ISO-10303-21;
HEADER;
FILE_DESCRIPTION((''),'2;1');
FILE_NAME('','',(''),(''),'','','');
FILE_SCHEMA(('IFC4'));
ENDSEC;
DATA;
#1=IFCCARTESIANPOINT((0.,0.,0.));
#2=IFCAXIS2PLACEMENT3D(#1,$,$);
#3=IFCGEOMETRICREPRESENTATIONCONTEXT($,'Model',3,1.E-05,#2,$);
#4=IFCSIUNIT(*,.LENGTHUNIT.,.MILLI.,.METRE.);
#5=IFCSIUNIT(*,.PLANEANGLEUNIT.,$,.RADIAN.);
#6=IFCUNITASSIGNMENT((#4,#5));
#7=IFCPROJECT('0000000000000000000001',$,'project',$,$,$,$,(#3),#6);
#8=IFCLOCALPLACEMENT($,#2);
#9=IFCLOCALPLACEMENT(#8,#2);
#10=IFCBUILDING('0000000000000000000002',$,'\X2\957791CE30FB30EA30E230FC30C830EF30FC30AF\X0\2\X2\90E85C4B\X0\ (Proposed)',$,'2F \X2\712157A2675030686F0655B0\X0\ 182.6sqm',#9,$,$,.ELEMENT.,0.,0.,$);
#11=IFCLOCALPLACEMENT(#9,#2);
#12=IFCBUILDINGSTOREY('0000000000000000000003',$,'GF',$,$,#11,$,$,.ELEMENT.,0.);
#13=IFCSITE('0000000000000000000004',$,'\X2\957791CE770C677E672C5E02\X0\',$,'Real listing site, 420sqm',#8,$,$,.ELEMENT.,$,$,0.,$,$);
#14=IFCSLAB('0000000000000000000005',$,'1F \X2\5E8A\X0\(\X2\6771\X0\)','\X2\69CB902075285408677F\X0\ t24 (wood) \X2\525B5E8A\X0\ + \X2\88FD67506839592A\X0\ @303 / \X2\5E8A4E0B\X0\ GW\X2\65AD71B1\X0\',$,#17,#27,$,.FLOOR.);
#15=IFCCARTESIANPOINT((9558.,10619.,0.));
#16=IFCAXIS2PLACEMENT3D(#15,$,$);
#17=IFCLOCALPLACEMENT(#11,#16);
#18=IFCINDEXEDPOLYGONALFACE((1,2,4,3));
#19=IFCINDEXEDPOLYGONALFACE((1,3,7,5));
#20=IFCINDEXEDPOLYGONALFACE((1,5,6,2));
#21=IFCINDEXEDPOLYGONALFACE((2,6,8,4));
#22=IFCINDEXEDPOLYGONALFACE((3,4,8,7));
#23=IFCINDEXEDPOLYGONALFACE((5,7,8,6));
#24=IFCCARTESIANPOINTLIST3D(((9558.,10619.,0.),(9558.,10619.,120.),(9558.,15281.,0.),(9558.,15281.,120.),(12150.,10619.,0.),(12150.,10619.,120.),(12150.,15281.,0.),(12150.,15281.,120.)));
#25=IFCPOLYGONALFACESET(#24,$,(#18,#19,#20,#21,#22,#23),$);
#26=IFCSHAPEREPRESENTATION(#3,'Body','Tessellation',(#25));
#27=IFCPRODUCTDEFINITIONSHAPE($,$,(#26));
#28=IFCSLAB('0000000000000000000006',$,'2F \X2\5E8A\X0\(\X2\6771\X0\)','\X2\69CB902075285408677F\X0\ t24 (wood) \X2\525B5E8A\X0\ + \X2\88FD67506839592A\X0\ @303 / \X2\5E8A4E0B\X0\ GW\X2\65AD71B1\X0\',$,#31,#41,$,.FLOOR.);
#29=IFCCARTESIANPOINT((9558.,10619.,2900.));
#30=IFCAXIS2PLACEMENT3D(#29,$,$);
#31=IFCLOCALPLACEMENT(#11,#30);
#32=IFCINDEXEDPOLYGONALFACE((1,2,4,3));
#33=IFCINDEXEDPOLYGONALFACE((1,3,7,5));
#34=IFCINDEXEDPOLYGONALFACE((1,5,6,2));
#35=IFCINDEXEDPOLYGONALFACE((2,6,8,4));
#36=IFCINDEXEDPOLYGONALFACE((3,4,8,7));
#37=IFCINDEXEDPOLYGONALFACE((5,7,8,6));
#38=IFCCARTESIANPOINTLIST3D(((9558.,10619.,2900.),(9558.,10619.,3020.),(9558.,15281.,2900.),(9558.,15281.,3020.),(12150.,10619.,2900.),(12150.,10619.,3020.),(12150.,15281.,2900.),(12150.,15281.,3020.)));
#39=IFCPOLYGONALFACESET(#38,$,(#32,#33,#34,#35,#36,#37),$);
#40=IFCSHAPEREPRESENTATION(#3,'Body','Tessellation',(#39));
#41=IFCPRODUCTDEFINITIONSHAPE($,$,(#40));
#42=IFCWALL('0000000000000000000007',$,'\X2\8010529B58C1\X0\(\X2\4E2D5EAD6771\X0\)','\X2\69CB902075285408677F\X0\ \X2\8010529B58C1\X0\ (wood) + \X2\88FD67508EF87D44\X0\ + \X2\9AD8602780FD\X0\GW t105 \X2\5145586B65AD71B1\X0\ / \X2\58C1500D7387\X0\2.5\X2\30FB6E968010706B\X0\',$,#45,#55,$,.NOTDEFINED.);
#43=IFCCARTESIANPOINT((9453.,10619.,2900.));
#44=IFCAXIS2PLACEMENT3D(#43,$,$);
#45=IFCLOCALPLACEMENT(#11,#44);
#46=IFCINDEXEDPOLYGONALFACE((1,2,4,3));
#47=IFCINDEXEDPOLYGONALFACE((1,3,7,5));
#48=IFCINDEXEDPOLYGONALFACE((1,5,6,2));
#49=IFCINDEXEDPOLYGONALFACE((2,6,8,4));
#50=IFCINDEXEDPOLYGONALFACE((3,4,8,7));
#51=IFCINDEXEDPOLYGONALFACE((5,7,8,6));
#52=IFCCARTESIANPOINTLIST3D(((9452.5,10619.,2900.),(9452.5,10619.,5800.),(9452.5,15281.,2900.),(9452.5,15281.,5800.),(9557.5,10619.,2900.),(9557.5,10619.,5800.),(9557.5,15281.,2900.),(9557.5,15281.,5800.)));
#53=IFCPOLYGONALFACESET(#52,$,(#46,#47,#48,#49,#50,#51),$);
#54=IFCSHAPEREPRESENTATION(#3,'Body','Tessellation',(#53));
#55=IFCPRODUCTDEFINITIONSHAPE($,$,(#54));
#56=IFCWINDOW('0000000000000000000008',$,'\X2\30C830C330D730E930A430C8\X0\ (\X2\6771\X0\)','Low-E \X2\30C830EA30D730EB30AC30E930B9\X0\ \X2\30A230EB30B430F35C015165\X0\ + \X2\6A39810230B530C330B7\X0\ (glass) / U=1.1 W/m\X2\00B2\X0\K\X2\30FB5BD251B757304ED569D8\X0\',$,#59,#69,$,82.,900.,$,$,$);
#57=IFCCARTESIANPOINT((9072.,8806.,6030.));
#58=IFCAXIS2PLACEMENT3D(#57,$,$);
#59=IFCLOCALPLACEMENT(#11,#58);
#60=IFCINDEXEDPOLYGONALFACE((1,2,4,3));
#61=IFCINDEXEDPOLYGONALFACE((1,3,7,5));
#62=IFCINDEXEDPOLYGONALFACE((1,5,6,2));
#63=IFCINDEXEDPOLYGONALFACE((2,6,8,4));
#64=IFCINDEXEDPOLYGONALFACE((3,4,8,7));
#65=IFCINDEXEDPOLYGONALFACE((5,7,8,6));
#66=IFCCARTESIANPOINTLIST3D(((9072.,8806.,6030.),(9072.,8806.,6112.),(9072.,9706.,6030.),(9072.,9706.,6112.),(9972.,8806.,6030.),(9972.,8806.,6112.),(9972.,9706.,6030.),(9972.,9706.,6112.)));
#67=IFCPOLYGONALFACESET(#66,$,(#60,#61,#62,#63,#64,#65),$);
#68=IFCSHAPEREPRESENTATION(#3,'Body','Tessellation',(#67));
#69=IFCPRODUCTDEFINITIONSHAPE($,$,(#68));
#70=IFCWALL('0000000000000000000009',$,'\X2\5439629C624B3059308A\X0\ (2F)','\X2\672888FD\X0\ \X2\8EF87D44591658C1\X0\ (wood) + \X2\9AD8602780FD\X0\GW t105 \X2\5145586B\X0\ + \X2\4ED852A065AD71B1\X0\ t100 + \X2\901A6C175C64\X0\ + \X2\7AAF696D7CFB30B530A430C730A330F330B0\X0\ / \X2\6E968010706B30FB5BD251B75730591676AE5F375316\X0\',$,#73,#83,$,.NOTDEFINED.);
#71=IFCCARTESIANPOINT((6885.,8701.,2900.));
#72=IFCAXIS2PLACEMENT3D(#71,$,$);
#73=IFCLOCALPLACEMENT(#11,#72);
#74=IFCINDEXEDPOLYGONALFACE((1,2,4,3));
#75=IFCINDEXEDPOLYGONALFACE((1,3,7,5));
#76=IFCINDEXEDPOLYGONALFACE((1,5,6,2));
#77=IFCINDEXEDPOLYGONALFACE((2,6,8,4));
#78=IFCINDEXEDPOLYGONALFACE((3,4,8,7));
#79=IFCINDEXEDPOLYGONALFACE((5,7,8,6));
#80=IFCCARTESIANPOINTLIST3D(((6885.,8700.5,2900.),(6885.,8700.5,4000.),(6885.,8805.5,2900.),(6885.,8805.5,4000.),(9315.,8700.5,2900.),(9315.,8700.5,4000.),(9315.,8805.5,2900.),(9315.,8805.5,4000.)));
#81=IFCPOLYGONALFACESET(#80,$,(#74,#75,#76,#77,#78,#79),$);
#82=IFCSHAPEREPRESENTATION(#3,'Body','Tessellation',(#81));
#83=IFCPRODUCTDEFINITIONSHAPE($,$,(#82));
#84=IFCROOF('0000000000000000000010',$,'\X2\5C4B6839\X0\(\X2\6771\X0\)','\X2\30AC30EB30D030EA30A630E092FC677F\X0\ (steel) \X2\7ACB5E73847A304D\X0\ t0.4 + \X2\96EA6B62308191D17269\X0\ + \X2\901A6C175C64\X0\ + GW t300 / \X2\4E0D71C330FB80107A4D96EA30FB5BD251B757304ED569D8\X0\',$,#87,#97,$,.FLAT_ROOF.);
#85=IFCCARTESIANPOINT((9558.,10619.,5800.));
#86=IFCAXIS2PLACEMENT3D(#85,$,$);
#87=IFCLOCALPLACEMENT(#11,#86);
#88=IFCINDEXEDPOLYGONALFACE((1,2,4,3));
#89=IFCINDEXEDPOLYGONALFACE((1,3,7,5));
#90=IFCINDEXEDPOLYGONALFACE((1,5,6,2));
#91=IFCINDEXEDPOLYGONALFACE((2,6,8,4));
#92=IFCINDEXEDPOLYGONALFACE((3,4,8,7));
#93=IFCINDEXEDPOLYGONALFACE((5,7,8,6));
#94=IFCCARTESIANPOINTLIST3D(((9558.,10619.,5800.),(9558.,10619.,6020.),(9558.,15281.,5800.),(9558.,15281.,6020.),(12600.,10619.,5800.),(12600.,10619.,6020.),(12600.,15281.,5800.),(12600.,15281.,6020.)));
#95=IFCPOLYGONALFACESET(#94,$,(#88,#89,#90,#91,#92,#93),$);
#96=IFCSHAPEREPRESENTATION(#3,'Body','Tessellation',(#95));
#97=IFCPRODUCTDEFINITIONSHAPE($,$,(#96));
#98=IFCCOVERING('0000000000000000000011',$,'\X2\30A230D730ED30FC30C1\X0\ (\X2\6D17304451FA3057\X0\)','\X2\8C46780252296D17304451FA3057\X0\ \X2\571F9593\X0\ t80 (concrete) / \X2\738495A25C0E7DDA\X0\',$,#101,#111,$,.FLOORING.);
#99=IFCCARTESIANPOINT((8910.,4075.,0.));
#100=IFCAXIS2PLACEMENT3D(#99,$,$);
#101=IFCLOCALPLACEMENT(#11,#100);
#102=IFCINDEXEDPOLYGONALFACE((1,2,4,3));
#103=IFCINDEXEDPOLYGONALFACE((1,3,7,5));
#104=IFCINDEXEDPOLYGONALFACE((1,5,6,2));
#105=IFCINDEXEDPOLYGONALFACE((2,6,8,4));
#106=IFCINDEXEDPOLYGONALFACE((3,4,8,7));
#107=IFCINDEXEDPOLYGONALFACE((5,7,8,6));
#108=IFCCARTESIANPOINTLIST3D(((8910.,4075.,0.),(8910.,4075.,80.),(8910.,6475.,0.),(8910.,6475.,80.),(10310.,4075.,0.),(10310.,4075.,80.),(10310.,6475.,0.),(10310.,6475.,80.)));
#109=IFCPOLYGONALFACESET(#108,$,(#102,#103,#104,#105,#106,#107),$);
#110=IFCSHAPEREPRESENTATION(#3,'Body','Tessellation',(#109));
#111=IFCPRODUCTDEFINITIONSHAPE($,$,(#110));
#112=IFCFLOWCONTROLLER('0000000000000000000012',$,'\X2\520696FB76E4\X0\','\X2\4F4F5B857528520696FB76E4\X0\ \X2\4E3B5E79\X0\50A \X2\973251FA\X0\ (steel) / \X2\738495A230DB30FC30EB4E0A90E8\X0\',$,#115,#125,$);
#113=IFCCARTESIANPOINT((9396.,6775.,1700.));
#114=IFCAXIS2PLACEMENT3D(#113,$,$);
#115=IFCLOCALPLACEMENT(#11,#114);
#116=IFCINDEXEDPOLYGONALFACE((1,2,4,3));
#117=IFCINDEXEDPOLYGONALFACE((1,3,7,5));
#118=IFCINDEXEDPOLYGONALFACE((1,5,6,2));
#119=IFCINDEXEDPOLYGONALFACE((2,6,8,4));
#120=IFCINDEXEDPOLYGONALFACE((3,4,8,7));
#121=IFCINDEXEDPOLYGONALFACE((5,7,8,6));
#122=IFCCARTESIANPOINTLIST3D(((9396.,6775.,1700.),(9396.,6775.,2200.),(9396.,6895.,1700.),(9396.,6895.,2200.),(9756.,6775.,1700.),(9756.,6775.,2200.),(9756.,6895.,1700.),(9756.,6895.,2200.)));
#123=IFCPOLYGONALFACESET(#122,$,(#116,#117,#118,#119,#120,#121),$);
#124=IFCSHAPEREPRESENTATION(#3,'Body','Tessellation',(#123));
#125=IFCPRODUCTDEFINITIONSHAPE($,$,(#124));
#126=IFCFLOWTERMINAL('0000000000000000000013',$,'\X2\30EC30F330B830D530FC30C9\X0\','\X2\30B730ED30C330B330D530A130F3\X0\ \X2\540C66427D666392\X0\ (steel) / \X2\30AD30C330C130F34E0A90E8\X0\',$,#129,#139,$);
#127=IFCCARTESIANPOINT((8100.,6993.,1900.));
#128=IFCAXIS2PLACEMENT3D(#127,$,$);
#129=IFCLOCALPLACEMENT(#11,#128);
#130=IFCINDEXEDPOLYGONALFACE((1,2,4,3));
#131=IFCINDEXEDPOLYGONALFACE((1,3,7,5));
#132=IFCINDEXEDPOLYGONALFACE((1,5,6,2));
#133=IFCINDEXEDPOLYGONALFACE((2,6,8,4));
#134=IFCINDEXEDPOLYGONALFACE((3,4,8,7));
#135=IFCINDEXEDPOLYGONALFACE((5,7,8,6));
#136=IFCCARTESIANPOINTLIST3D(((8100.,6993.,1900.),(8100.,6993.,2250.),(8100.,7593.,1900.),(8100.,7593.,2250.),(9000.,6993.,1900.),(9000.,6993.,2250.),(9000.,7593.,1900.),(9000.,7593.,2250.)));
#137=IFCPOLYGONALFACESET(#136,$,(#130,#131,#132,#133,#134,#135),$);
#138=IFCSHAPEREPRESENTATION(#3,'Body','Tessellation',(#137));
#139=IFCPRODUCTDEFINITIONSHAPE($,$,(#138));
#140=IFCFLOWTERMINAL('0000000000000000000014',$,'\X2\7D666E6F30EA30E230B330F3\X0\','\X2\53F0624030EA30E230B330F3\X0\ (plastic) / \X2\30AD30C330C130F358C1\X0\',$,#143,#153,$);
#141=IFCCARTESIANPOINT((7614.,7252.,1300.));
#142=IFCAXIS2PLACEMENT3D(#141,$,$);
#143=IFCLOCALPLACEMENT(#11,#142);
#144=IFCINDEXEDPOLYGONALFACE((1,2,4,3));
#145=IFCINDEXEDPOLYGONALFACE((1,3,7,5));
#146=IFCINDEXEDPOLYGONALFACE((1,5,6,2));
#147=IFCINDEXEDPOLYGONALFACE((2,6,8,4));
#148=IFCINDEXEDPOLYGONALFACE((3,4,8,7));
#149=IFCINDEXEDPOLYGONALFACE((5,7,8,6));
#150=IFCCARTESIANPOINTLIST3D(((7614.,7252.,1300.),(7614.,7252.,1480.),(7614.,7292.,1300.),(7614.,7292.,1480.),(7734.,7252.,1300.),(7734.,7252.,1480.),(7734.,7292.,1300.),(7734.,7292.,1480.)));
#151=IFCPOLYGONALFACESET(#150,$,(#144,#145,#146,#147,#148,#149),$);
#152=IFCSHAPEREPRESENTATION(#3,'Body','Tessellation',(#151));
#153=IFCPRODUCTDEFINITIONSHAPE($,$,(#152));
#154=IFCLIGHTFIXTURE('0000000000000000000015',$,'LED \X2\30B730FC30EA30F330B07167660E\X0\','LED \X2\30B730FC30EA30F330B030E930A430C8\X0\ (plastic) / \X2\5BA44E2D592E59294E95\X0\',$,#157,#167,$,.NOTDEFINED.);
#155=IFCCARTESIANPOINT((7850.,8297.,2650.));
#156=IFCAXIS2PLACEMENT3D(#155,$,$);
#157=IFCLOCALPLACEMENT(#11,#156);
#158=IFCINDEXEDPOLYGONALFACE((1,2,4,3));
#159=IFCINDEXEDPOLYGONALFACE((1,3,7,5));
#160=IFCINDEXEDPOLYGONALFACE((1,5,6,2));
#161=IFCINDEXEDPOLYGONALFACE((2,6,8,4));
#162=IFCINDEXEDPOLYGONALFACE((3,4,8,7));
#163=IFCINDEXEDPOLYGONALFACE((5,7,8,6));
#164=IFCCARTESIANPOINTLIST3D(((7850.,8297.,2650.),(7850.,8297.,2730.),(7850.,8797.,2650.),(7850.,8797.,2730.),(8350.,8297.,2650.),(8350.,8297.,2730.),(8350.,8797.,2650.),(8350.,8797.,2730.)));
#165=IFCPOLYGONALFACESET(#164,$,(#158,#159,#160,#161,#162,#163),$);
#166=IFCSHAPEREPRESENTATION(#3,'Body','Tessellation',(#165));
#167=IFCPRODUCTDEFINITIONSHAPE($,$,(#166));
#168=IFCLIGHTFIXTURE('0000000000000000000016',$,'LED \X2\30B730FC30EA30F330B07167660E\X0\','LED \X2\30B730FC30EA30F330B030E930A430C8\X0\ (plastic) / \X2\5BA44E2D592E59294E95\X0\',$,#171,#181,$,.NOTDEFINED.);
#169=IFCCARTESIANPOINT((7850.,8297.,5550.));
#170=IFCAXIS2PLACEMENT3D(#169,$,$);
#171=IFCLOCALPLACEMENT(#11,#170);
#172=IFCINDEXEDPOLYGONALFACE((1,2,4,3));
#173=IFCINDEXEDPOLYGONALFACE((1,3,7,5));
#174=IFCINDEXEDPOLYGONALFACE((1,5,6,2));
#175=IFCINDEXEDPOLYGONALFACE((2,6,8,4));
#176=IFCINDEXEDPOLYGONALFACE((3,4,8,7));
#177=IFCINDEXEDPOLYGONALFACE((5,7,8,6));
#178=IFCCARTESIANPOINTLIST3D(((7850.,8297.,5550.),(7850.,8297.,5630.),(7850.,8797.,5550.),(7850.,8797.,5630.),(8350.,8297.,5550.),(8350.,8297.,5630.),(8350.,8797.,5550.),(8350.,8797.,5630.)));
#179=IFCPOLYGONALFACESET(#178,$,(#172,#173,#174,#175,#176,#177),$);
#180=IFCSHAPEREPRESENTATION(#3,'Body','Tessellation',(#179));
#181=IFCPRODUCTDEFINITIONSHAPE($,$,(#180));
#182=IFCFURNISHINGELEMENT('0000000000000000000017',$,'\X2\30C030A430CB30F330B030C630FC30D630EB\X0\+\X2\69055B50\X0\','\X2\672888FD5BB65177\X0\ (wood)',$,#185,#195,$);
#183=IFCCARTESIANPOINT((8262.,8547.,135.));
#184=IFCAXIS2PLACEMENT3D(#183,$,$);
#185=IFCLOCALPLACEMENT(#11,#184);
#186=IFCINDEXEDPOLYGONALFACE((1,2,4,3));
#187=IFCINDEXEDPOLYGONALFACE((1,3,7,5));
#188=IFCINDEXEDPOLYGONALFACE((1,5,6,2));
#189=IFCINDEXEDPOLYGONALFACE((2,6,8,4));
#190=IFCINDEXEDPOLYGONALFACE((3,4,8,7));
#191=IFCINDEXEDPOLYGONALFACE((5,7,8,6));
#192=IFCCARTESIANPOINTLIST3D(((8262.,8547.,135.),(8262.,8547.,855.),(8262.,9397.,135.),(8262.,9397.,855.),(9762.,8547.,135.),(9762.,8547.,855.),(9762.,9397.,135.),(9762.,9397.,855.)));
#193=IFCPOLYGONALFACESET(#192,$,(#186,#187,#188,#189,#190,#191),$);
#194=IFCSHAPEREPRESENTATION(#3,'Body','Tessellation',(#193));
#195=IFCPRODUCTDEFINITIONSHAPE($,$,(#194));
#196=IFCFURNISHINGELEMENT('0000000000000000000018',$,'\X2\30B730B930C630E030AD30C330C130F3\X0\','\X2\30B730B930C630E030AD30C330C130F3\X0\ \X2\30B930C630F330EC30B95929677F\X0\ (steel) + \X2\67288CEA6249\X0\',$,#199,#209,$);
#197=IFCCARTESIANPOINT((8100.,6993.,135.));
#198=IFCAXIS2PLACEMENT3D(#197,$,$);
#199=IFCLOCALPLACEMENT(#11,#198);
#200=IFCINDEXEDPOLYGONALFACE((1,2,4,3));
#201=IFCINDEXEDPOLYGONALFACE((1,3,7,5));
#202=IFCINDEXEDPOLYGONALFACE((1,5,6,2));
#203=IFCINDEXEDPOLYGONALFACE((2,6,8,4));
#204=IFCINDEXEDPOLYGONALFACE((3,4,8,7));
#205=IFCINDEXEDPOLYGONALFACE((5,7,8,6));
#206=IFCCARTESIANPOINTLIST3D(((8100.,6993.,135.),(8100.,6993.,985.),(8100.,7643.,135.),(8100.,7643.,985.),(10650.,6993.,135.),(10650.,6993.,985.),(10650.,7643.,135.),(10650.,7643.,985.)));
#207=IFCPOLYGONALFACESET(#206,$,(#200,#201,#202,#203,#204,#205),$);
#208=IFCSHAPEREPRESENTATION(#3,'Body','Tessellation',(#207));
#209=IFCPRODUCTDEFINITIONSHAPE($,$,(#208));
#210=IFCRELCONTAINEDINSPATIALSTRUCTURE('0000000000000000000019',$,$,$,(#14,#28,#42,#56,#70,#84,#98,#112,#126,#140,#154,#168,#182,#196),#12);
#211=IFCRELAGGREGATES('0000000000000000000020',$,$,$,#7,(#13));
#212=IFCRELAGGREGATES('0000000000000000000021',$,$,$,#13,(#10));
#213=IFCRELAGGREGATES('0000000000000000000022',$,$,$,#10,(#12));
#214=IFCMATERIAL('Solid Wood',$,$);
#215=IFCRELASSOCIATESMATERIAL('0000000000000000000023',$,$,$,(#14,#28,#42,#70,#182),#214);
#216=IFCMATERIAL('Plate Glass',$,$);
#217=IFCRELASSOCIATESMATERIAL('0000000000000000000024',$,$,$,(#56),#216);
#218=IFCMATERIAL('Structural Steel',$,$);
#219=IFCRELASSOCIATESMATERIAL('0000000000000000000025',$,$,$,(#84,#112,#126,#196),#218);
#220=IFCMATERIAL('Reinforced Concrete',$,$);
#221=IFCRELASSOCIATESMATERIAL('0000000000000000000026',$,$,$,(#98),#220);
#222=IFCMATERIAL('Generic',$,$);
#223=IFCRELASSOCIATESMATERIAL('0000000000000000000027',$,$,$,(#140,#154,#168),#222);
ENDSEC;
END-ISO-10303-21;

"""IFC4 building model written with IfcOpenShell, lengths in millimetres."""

from ifc_helpers import new_model, si_unit, frame, frame_2d, origin, place, context, project, spatial, rectangle, extrude, material, element, save


model = new_model("IFC4")

# Units and contexts
model_context = context("Model", 3, precision=1e-05, world=origin())
ifc_project = project(units=[si_unit("LENGTHUNIT", "METRE", prefix="MILLI"), si_unit("PLANEANGLEUNIT", "RADIAN")], contexts=[model_context])

# Site, building, storey
site_placement = place(None, origin())
site = spatial("IfcSite", under=ifc_project, at=site_placement, Name="長野県松本市", ObjectType="Real listing site, 420sqm", CompositionType="ELEMENT", RefElevation=0.0)
building_placement = place(site_placement, origin())
building = spatial("IfcBuilding", under=site, at=building_placement, Name="長野・リモートワーク2部屋 (Proposed)", ObjectType="2F 無垢材と漆喰 182.6sqm", CompositionType="ELEMENT", ElevationOfRefHeight=0.0, ElevationOfTerrain=0.0)
storey_placement = place(building_placement, origin())
storey = spatial("IfcBuildingStorey", under=building, at=storey_placement, Name="GF", CompositionType="ELEMENT", Elevation=0.0)

# Shared definitions
ifc_material_1 = material(Name="Solid Wood")

# Slabs
slab_1_placement = place(storey_placement, frame((9558.0, 10619.0, 0.0)))
element("IfcSlab", 1, at=slab_1_placement, inside=storey, material=ifc_material_1, Name="1F 床(東)", Description="構造用合板 t24 (wood) 剛床 + 製材根太 @303 / 床下 GW断熱", PredefinedType="FLOOR", context=model_context, shape_type="SweptSolid", body=[
    extrude(rectangle(XDim=2592.0, YDim=4662.0, at=frame_2d((1296.0, 2331.0))), frame((9558.0, 10619.0, 0.0)), (0.0, 0.0, 1.0), 120.0),
])
slab_2_placement = place(storey_placement, frame((9558.0, 10619.0, 2900.0)))
element("IfcSlab", 2, at=slab_2_placement, inside=storey, material=ifc_material_1, Name="2F 床(東)", Description="構造用合板 t24 (wood) 剛床 + 製材根太 @303 / 床下 GW断熱", PredefinedType="FLOOR", context=model_context, shape_type="SweptSolid", body=[
    extrude(rectangle(XDim=2592.0, YDim=4662.0, at=frame_2d((1296.0, 2331.0))), frame((9558.0, 10619.0, 2900.0)), (0.0, 0.0, 1.0), 120.0),
])

# Wall
wall_1_placement = place(storey_placement, frame((9453.0, 10619.0, 2900.0)))
element("IfcWall", 3, at=wall_1_placement, inside=storey, material=ifc_material_1, Name="耐力壁(中庭東)", Description="構造用合板 耐力壁 (wood) + 製材軸組 + 高性能GW t105 充填断熱 / 壁倍率2.5・準耐火", PredefinedType="NOTDEFINED", context=model_context, shape_type="SweptSolid", body=[
    extrude(rectangle(XDim=105.0, YDim=4662.0, at=frame_2d((52.0, 2331.0))), frame((9453.0, 10619.0, 2900.0)), (0.0, 0.0, 1.0), 2900.0),
])

# Window
ifc_material_2 = material(Name="Plate Glass")
window_placement = place(storey_placement, frame((9072.0, 8806.0, 6030.0)))
element("IfcWindow", 4, at=window_placement, inside=storey, material=ifc_material_2, Name="トップライト (東)", Description="Low-E トリプルガラス アルゴン封入 + 樹脂サッシ (glass) / U=1.1 W/m²K・寒冷地仕様", OverallHeight=82.0, OverallWidth=900.0, context=model_context, shape_type="SweptSolid", body=[
    extrude(rectangle(XDim=900.0, YDim=900.0, at=frame_2d((450.0, 450.0))), frame((9072.0, 8806.0, 6030.0)), (0.0, 0.0, 1.0), 82.0),
])

# Wall
wall_2_placement = place(storey_placement, frame((6885.0, 8701.0, 2900.0)))
element("IfcWall", 5, at=wall_2_placement, inside=storey, material=ifc_material_1, Name="吹抜手すり (2F)", Description="木製 軸組外壁 (wood) + 高性能GW t105 充填 + 付加断熱 t100 + 通気層 + 窯業系サイディング / 準耐火・寒冷地外皮強化", PredefinedType="NOTDEFINED", context=model_context, shape_type="SweptSolid", body=[
    extrude(rectangle(XDim=2430.0, YDim=105.0, at=frame_2d((1215.0, 52.0))), frame((6885.0, 8701.0, 2900.0)), (0.0, 0.0, 1.0), 1100.0),
])

# Roof
ifc_material_3 = material(Name="Structural Steel")
roof_placement = place(storey_placement, frame((9558.0, 10619.0, 5800.0)))
element("IfcRoof", 6, at=roof_placement, inside=storey, material=ifc_material_3, Name="屋根(東)", Description="ガルバリウム鋼板 (steel) 立平葺き t0.4 + 雪止め金物 + 通気層 + GW t300 / 不燃・耐積雪・寒冷地仕様", PredefinedType="FLAT_ROOF", context=model_context, shape_type="SweptSolid", body=[
    extrude(rectangle(XDim=3042.0, YDim=4662.0, at=frame_2d((1521.0, 2331.0))), frame((9558.0, 10619.0, 5800.0)), (0.0, 0.0, 1.0), 220.0),
])

# Covering
ifc_material_4 = material(Name="Reinforced Concrete")
covering_placement = place(storey_placement, frame((8910.0, 4075.0, 0.0)))
element("IfcCovering", 7, at=covering_placement, inside=storey, material=ifc_material_4, Name="アプローチ (洗い出し)", Description="豆砂利洗い出し 土間 t80 (concrete) / 玄関導線", PredefinedType="FLOORING", context=model_context, shape_type="SweptSolid", body=[
    extrude(rectangle(XDim=1400.0, YDim=2400.0, at=frame_2d((700.0, 1200.0))), frame((8910.0, 4075.0, 0.0)), (0.0, 0.0, 1.0), 80.0),
])

# Flow controller
flow_controller_placement = place(storey_placement, frame((9396.0, 6775.0, 1700.0)))
element("IfcFlowController", 8, at=flow_controller_placement, inside=storey, material=ifc_material_3, Name="分電盤", Description="住宅用分電盤 主幹50A 露出 (steel) / 玄関ホール上部", context=model_context, shape_type="SweptSolid", body=[
    extrude(rectangle(XDim=360.0, YDim=120.0, at=frame_2d((180.0, 60.0))), frame((9396.0, 6775.0, 1700.0)), (0.0, 0.0, 1.0), 500.0),
])

# Flow terminals
flow_terminal_1_placement = place(storey_placement, frame((8100.0, 6993.0, 1900.0)))
element("IfcFlowTerminal", 9, at=flow_terminal_1_placement, inside=storey, material=ifc_material_3, Name="レンジフード", Description="シロッコファン 同時給排 (steel) / キッチン上部", context=model_context, shape_type="SweptSolid", body=[
    extrude(rectangle(XDim=900.0, YDim=600.0, at=frame_2d((450.0, 300.0))), frame((8100.0, 6993.0, 1900.0)), (0.0, 0.0, 1.0), 350.0),
])
ifc_material_5 = material(Name="Generic")
flow_terminal_2_placement = place(storey_placement, frame((7614.0, 7252.0, 1300.0)))
element("IfcFlowTerminal", 10, at=flow_terminal_2_placement, inside=storey, material=ifc_material_5, Name="給湯リモコン", Description="台所リモコン (plastic) / キッチン壁", context=model_context, shape_type="SweptSolid", body=[
    extrude(rectangle(XDim=120.0, YDim=40.0, at=frame_2d((60.0, 20.0))), frame((7614.0, 7252.0, 1300.0)), (0.0, 0.0, 1.0), 180.0),
])

# Light fixtures
light_fixture_1_placement = place(storey_placement, frame((7850.0, 8297.0, 2650.0)))
element("IfcLightFixture", 11, at=light_fixture_1_placement, inside=storey, material=ifc_material_5, Name="LED シーリング照明", Description="LED シーリングライト (plastic) / 室中央天井", PredefinedType="NOTDEFINED", context=model_context, shape_type="SweptSolid", body=[
    extrude(rectangle(XDim=500.0, YDim=500.0, at=frame_2d((250.0, 250.0))), frame((7850.0, 8297.0, 2650.0)), (0.0, 0.0, 1.0), 80.0),
])
light_fixture_2_placement = place(storey_placement, frame((7850.0, 8297.0, 5550.0)))
element("IfcLightFixture", 12, at=light_fixture_2_placement, inside=storey, material=ifc_material_5, Name="LED シーリング照明", Description="LED シーリングライト (plastic) / 室中央天井", PredefinedType="NOTDEFINED", context=model_context, shape_type="SweptSolid", body=[
    extrude(rectangle(XDim=500.0, YDim=500.0, at=frame_2d((250.0, 250.0))), frame((7850.0, 8297.0, 5550.0)), (0.0, 0.0, 1.0), 80.0),
])

# Furnishing elements
furnishing_1_placement = place(storey_placement, frame((8262.0, 8547.0, 135.0)))
element("IfcFurnishingElement", 13, at=furnishing_1_placement, inside=storey, material=ifc_material_1, Name="ダイニングテーブル+椅子", Description="木製家具 (wood)", context=model_context, shape_type="SweptSolid", body=[
    extrude(rectangle(XDim=1500.0, YDim=850.0, at=frame_2d((750.0, 425.0))), frame((8262.0, 8547.0, 135.0)), (0.0, 0.0, 1.0), 720.0),
])
furnishing_2_placement = place(storey_placement, frame((8100.0, 6993.0, 135.0)))
element("IfcFurnishingElement", 14, at=furnishing_2_placement, inside=storey, material=ifc_material_3, Name="システムキッチン", Description="システムキッチン ステンレス天板 (steel) + 木質扉", context=model_context, shape_type="SweptSolid", body=[
    extrude(rectangle(XDim=2550.0, YDim=650.0, at=frame_2d((1275.0, 325.0))), frame((8100.0, 6993.0, 135.0)), (0.0, 0.0, 1.0), 850.0),
])

save(model, "model.ifc")
